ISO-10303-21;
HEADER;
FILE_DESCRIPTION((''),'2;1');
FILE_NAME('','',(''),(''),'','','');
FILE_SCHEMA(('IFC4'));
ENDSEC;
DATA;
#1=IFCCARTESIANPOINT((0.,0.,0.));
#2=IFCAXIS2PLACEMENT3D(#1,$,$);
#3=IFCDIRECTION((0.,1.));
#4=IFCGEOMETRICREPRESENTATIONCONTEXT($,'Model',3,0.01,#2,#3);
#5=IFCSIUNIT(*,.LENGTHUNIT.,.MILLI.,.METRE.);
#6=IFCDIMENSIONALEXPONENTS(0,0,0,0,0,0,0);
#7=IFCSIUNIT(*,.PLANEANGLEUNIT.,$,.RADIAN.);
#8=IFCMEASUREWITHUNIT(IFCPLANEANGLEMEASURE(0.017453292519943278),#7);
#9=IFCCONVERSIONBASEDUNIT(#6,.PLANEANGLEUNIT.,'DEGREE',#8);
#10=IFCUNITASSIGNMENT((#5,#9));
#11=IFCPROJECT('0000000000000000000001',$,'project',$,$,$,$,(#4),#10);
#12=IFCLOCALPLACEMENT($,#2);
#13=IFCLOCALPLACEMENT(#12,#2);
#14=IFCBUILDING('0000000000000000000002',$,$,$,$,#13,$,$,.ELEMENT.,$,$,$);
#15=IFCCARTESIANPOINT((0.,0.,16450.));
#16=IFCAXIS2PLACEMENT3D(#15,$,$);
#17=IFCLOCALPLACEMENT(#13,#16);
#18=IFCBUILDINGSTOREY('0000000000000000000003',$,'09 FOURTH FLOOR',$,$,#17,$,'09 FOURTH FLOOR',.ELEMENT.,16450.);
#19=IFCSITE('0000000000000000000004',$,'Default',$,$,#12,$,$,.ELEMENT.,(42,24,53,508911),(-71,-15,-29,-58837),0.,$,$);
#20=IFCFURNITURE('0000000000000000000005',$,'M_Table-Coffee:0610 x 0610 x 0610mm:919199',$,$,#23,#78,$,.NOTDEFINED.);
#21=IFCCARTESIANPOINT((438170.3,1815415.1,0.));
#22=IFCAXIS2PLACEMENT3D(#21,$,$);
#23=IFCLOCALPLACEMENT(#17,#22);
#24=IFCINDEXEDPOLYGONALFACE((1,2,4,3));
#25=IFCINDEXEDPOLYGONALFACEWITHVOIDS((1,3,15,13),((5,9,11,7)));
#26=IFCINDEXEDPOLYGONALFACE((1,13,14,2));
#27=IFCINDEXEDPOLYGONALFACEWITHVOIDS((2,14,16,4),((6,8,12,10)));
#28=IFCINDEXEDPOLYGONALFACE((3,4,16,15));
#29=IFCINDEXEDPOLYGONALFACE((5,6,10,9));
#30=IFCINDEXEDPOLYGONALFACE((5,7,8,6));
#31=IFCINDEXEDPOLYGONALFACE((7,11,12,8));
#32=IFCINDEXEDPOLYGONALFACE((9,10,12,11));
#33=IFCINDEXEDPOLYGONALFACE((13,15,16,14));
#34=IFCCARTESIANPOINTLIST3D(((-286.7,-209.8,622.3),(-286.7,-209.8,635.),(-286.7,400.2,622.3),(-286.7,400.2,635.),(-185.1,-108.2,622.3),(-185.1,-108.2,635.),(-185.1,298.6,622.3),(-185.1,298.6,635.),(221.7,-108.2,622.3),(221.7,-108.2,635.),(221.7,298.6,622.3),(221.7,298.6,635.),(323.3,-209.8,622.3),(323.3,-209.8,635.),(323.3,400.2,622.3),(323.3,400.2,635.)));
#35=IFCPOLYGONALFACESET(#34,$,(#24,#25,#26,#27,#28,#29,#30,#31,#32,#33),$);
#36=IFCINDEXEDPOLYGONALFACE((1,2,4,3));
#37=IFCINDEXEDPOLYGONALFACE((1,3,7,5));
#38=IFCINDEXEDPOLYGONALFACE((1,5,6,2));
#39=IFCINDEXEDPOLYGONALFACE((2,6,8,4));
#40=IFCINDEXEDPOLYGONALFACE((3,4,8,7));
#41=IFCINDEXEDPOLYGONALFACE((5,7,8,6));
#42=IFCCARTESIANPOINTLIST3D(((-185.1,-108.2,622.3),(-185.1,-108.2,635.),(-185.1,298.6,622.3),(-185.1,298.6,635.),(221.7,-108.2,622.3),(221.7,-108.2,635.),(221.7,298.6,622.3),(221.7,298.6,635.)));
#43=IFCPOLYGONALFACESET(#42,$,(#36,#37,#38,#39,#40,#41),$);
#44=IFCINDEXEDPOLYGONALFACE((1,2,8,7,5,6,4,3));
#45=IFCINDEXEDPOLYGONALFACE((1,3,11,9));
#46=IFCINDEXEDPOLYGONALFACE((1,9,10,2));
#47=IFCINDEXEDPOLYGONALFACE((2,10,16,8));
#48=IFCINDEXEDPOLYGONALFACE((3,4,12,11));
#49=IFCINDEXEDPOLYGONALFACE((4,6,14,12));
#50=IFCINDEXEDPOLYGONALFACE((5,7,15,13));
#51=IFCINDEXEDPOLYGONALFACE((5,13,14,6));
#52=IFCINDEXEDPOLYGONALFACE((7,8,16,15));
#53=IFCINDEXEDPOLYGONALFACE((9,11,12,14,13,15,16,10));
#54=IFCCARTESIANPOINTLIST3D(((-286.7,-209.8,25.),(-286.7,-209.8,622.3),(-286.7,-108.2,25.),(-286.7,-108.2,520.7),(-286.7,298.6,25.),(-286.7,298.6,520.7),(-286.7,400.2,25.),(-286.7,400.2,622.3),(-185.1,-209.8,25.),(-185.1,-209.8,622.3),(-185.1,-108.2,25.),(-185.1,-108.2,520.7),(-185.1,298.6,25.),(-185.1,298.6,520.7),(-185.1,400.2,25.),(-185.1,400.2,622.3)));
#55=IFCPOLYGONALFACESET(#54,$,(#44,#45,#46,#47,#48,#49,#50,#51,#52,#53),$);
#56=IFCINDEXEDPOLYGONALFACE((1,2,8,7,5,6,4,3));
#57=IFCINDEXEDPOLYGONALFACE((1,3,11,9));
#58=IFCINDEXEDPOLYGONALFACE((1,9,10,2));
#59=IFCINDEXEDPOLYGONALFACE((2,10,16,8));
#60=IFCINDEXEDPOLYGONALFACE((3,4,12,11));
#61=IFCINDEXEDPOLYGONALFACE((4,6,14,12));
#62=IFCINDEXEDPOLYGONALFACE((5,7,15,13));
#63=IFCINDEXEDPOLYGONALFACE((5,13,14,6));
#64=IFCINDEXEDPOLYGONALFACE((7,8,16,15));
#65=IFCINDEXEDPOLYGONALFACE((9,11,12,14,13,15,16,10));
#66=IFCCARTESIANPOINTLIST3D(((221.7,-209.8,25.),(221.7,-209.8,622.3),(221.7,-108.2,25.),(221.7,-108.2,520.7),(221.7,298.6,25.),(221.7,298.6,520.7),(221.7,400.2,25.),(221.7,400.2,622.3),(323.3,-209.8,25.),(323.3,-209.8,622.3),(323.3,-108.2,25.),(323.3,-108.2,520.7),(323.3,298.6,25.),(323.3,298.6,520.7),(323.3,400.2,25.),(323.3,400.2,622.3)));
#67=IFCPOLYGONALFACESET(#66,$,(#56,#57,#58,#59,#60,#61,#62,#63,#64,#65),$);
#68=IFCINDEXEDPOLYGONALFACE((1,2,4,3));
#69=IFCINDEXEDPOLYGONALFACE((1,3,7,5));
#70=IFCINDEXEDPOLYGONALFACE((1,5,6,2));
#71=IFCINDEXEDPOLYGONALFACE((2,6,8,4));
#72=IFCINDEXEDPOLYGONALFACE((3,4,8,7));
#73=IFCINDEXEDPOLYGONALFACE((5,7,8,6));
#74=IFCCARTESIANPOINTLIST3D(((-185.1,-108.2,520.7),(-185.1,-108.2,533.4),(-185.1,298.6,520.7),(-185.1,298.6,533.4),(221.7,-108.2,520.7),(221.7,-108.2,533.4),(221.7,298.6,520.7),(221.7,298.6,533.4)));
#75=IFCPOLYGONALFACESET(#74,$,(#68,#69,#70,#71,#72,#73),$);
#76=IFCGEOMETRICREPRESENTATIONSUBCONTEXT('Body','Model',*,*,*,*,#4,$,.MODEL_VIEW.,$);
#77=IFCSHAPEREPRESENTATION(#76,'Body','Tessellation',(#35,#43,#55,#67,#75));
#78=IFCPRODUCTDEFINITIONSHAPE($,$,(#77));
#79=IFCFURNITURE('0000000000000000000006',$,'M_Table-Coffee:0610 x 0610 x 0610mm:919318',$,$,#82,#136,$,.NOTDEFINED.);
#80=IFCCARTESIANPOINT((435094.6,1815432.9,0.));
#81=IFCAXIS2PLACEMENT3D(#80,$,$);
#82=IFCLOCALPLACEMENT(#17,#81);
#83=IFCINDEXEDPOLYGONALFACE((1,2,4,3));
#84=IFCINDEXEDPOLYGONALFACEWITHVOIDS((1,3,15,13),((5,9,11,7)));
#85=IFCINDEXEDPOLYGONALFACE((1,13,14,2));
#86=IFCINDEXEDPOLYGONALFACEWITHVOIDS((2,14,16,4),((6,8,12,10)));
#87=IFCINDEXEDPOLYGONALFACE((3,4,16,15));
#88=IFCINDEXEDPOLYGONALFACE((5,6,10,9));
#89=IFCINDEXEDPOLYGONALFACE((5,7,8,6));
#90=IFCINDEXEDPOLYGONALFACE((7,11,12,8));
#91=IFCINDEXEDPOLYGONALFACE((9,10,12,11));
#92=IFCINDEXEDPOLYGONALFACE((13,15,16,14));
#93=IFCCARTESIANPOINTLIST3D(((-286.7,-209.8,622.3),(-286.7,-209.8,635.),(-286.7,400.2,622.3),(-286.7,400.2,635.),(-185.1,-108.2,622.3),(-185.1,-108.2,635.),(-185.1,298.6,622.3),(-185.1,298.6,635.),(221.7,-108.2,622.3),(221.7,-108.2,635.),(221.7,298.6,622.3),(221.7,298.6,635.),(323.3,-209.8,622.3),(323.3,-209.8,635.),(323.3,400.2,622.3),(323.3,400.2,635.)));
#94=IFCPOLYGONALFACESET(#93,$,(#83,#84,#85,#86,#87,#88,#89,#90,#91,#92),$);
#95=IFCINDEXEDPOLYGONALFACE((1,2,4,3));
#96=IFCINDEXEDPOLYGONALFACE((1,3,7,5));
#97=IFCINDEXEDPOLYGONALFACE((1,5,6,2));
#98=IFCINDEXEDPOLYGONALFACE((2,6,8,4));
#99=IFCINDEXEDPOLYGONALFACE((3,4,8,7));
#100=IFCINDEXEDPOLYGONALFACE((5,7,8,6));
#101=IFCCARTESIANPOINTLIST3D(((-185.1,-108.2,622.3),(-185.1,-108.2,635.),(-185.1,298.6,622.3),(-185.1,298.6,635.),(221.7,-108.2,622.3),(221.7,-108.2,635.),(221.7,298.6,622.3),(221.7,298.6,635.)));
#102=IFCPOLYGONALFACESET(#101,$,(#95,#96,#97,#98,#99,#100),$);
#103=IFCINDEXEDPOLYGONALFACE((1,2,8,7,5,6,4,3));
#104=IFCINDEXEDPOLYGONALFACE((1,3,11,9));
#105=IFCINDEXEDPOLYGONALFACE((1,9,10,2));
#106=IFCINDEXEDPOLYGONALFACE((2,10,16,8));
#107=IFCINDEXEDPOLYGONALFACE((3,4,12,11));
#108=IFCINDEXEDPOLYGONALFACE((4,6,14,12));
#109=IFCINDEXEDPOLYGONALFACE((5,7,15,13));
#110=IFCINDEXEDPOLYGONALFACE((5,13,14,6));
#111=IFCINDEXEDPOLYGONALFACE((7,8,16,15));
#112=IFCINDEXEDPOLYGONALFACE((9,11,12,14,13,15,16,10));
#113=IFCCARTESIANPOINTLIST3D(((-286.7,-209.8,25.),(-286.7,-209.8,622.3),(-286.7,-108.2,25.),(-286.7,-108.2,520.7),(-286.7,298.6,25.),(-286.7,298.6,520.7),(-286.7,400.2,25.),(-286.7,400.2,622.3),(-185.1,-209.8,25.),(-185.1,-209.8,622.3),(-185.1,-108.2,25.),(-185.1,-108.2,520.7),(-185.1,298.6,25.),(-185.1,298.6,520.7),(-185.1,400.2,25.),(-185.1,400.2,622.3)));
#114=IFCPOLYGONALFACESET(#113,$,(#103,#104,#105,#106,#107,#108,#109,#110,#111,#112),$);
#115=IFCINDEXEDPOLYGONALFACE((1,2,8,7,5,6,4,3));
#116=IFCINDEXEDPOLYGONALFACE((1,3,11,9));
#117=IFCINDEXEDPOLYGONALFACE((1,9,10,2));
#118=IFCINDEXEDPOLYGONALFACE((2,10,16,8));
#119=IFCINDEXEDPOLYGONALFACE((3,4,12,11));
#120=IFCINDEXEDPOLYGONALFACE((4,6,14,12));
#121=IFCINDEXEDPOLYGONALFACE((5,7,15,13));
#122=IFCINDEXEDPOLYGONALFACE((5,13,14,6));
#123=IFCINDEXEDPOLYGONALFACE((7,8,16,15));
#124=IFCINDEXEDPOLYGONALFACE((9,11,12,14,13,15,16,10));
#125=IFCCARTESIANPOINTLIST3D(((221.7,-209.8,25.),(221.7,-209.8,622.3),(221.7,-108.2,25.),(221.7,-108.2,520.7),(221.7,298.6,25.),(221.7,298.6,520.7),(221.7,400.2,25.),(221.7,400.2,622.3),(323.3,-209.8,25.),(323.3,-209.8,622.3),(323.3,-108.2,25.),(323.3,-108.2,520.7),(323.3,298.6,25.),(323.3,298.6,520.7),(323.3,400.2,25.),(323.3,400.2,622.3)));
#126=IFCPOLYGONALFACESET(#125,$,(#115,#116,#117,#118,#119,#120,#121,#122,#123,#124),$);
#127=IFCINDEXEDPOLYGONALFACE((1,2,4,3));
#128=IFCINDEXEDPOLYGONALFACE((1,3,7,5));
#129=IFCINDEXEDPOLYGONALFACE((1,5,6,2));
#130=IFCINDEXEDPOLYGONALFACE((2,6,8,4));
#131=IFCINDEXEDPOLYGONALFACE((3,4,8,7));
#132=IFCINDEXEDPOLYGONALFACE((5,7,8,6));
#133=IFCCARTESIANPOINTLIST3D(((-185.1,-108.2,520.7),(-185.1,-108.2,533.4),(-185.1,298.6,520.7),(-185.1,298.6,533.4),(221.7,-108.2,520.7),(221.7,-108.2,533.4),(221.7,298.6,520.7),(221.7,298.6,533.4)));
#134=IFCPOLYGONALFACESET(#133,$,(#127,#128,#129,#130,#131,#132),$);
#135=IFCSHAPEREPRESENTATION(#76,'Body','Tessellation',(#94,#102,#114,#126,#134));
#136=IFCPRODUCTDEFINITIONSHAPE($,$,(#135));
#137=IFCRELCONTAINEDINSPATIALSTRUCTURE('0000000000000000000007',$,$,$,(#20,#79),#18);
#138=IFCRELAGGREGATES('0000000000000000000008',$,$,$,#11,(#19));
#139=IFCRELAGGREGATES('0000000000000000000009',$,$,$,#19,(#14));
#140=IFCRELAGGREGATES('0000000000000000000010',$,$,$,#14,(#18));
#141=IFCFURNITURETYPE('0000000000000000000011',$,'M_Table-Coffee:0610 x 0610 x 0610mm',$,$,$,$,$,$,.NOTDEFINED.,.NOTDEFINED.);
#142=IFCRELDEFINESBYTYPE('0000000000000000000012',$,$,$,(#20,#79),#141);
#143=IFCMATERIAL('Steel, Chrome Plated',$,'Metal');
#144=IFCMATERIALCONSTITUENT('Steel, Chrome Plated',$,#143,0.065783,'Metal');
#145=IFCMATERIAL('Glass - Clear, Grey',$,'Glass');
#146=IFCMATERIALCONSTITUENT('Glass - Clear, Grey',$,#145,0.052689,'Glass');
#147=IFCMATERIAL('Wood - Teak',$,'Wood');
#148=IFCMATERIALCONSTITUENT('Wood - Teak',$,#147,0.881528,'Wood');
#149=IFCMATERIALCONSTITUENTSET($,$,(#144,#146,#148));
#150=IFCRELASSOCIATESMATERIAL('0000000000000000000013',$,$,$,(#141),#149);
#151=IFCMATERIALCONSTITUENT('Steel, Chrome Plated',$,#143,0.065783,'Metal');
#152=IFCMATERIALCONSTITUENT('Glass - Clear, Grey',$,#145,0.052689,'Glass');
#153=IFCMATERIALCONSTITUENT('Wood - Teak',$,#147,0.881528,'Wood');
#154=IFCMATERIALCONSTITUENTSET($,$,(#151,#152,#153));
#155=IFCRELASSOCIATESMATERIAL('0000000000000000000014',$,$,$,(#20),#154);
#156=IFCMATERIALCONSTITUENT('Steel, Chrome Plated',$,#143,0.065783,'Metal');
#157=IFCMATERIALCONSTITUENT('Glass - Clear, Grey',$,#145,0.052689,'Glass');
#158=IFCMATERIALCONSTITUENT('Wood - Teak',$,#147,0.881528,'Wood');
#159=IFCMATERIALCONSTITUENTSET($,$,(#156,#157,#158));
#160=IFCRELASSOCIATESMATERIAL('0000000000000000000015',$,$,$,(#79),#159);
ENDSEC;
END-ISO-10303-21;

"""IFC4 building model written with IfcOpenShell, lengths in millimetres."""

from ifc_helpers import new_model, entity, si_unit, converted_unit, direction, frame, origin, place, context, subcontext, project, spatial, indexed_curve, outline, extrude, source, transform, mapped, material, constituent, constituent_set, type_object, type_shapes, element, save


model = new_model("IFC4")

# Units and contexts
model_context = context("Model", 3, precision=0.01, world=origin(), true_north=direction((0.0, 1.0)))
body_context = subcontext(model_context, "Body", "Model", "MODEL_VIEW")
ifc_project = project(units=[si_unit("LENGTHUNIT", "METRE", prefix="MILLI"), converted_unit("PLANEANGLEUNIT", "DEGREE", entity("IfcPlaneAngleMeasure", 0.017453292519943278), si_unit("PLANEANGLEUNIT", "RADIAN"), dimensions=[0, 0, 0, 0, 0, 0, 0])], contexts=[model_context])

# Site, building, storey
site_placement = place(None, origin())
site = spatial("IfcSite", under=ifc_project, at=site_placement, Name="Default", CompositionType="ELEMENT", RefLatitude=(42, 24, 53, 508911), RefLongitude=(-71, -15, -29, -58837), RefElevation=0.0)
building_placement = place(site_placement, origin())
building = spatial("IfcBuilding", under=site, at=building_placement, CompositionType="ELEMENT")
storey_placement = place(building_placement, frame((0.0, 0.0, 16450.0)))
storey = spatial("IfcBuildingStorey", under=building, at=storey_placement, Name="09 FOURTH FLOOR", LongName="09 FOURTH FLOOR", CompositionType="ELEMENT", Elevation=16450.0)

# Furniture
ifc_material_1 = material(Name="Steel, Chrome Plated", Category="Metal")
ifc_constituent_1 = constituent(ifc_material_1, Name="Steel, Chrome Plated", Category="Metal", fraction=0.065783)
ifc_material_2 = material(Name="Glass - Clear, Grey", Category="Glass")
ifc_constituent_2 = constituent(ifc_material_2, Name="Glass - Clear, Grey", Category="Glass", fraction=0.052689)
ifc_material_3 = material(Name="Wood - Teak", Category="Wood")
ifc_constituent_3 = constituent(ifc_material_3, Name="Wood - Teak", Category="Wood", fraction=0.881528)
ifc_constituent_set_1 = constituent_set(constituents=[ifc_constituent_1, ifc_constituent_2, ifc_constituent_3])
ifc_constituent_4 = constituent(ifc_material_1, Name="Steel, Chrome Plated", Category="Metal", fraction=0.065783)
ifc_constituent_5 = constituent(ifc_material_2, Name="Glass - Clear, Grey", Category="Glass", fraction=0.052689)
ifc_constituent_6 = constituent(ifc_material_3, Name="Wood - Teak", Category="Wood", fraction=0.881528)
ifc_constituent_set_2 = constituent_set(constituents=[ifc_constituent_4, ifc_constituent_5, ifc_constituent_6])
furniture_type_1 = type_object("IfcFurnitureType", Name="M_Table-Coffee:0610 x 0610 x 0610mm", AssemblyPlace="NOTDEFINED", PredefinedType="NOTDEFINED", material=ifc_constituent_set_2)
shared_shape_1 = source(origin(), body_context, "Body", "SweptSolid", [
    extrude(outline(indexed_curve([(-305.0, -305.0), (305.0, -305.0), (305.0, 305.0), (-305.0, 305.0), (-305.0, -305.0)], self_intersect=False), holes=[indexed_curve([(-203.4, -203.4), (-203.4, 203.4), (203.4, 203.4), (203.4, -203.4), (-203.4, -203.4)], self_intersect=False)]), frame((18.3, 95.2, 622.3), z_axis=(0.0, 0.0, 1.0), x_axis=(-1.0, 0.0, 0.0)), (0.0, 0.0, 1.0), 12.7),
    extrude(outline(indexed_curve([(-203.4, -203.4), (203.4, -203.4), (203.4, 203.4), (-203.4, 203.4), (-203.4, -203.4)], self_intersect=False)), frame((18.3, 95.2, 622.3), z_axis=(0.0, 0.0, 1.0), x_axis=(-1.0, 0.0, 0.0)), (0.0, 0.0, 1.0), 12.7),
    extrude(outline(indexed_curve([(-305.0, -324.1), (305.0, -324.1), (305.0, 273.3), (203.4, 273.3), (203.4, -222.4), (-203.4, -222.4), (-203.4, 273.3), (-305.0, 273.3), (-305.0, -324.1)], self_intersect=False)), frame((-286.7, 95.2, 298.3), z_axis=(1.0, 0.0, 0.0), x_axis=(0.0, -1.0, 0.0)), (0.0, 0.0, 1.0), 101.6),
    extrude(outline(indexed_curve([(-273.2, -305.0), (324.0, -305.0), (324.0, 305.0), (-273.2, 305.0), (-273.2, 203.4), (222.5, 203.4), (222.5, -203.4), (-273.2, -203.4), (-273.2, -305.0)], self_intersect=False)), frame((221.7, 95.2, 298.2), z_axis=(1.0, 0.0, 0.0), x_axis=(0.0, 0.0, 1.0)), (0.0, 0.0, 1.0), 101.6),
    extrude(outline(indexed_curve([(-203.4, -203.4), (203.4, -203.4), (203.4, 203.4), (-203.4, 203.4), (-203.4, -203.4)], self_intersect=False)), frame((18.3, 95.2, 520.7), z_axis=(0.0, 0.0, 1.0), x_axis=(-1.0, 0.0, 0.0)), (0.0, 0.0, 1.0), 12.7),
])
type_shapes(furniture_type_1, [shared_shape_1])
furniture_1_placement = place(storey_placement, frame((438170.3, 1815415.1, 0.0)))
element("IfcFurniture", 1, at=furniture_1_placement, inside=storey, type_object=furniture_type_1, material=ifc_constituent_set_1, Name="M_Table-Coffee:0610 x 0610 x 0610mm:919199", PredefinedType="NOTDEFINED", context=body_context, shape_type="MappedRepresentation", body=[
    mapped(shared_shape_1, transform((0.0, 0.0, 0.0), scale=1.0)),
])
ifc_constituent_7 = constituent(ifc_material_1, Name="Steel, Chrome Plated", Category="Metal", fraction=0.065783)
ifc_constituent_8 = constituent(ifc_material_2, Name="Glass - Clear, Grey", Category="Glass", fraction=0.052689)
ifc_constituent_9 = constituent(ifc_material_3, Name="Wood - Teak", Category="Wood", fraction=0.881528)
ifc_constituent_set_3 = constituent_set(constituents=[ifc_constituent_7, ifc_constituent_8, ifc_constituent_9])
furniture_2_placement = place(storey_placement, frame((435094.6, 1815432.9, 0.0)))
element("IfcFurniture", 2, at=furniture_2_placement, inside=storey, type_object=furniture_type_1, material=ifc_constituent_set_3, Name="M_Table-Coffee:0610 x 0610 x 0610mm:919318", PredefinedType="NOTDEFINED", context=body_context, shape_type="MappedRepresentation", body=[
    mapped(shared_shape_1, transform((0.0, 0.0, 0.0), scale=1.0)),
])

save(model, "model.ifc")
